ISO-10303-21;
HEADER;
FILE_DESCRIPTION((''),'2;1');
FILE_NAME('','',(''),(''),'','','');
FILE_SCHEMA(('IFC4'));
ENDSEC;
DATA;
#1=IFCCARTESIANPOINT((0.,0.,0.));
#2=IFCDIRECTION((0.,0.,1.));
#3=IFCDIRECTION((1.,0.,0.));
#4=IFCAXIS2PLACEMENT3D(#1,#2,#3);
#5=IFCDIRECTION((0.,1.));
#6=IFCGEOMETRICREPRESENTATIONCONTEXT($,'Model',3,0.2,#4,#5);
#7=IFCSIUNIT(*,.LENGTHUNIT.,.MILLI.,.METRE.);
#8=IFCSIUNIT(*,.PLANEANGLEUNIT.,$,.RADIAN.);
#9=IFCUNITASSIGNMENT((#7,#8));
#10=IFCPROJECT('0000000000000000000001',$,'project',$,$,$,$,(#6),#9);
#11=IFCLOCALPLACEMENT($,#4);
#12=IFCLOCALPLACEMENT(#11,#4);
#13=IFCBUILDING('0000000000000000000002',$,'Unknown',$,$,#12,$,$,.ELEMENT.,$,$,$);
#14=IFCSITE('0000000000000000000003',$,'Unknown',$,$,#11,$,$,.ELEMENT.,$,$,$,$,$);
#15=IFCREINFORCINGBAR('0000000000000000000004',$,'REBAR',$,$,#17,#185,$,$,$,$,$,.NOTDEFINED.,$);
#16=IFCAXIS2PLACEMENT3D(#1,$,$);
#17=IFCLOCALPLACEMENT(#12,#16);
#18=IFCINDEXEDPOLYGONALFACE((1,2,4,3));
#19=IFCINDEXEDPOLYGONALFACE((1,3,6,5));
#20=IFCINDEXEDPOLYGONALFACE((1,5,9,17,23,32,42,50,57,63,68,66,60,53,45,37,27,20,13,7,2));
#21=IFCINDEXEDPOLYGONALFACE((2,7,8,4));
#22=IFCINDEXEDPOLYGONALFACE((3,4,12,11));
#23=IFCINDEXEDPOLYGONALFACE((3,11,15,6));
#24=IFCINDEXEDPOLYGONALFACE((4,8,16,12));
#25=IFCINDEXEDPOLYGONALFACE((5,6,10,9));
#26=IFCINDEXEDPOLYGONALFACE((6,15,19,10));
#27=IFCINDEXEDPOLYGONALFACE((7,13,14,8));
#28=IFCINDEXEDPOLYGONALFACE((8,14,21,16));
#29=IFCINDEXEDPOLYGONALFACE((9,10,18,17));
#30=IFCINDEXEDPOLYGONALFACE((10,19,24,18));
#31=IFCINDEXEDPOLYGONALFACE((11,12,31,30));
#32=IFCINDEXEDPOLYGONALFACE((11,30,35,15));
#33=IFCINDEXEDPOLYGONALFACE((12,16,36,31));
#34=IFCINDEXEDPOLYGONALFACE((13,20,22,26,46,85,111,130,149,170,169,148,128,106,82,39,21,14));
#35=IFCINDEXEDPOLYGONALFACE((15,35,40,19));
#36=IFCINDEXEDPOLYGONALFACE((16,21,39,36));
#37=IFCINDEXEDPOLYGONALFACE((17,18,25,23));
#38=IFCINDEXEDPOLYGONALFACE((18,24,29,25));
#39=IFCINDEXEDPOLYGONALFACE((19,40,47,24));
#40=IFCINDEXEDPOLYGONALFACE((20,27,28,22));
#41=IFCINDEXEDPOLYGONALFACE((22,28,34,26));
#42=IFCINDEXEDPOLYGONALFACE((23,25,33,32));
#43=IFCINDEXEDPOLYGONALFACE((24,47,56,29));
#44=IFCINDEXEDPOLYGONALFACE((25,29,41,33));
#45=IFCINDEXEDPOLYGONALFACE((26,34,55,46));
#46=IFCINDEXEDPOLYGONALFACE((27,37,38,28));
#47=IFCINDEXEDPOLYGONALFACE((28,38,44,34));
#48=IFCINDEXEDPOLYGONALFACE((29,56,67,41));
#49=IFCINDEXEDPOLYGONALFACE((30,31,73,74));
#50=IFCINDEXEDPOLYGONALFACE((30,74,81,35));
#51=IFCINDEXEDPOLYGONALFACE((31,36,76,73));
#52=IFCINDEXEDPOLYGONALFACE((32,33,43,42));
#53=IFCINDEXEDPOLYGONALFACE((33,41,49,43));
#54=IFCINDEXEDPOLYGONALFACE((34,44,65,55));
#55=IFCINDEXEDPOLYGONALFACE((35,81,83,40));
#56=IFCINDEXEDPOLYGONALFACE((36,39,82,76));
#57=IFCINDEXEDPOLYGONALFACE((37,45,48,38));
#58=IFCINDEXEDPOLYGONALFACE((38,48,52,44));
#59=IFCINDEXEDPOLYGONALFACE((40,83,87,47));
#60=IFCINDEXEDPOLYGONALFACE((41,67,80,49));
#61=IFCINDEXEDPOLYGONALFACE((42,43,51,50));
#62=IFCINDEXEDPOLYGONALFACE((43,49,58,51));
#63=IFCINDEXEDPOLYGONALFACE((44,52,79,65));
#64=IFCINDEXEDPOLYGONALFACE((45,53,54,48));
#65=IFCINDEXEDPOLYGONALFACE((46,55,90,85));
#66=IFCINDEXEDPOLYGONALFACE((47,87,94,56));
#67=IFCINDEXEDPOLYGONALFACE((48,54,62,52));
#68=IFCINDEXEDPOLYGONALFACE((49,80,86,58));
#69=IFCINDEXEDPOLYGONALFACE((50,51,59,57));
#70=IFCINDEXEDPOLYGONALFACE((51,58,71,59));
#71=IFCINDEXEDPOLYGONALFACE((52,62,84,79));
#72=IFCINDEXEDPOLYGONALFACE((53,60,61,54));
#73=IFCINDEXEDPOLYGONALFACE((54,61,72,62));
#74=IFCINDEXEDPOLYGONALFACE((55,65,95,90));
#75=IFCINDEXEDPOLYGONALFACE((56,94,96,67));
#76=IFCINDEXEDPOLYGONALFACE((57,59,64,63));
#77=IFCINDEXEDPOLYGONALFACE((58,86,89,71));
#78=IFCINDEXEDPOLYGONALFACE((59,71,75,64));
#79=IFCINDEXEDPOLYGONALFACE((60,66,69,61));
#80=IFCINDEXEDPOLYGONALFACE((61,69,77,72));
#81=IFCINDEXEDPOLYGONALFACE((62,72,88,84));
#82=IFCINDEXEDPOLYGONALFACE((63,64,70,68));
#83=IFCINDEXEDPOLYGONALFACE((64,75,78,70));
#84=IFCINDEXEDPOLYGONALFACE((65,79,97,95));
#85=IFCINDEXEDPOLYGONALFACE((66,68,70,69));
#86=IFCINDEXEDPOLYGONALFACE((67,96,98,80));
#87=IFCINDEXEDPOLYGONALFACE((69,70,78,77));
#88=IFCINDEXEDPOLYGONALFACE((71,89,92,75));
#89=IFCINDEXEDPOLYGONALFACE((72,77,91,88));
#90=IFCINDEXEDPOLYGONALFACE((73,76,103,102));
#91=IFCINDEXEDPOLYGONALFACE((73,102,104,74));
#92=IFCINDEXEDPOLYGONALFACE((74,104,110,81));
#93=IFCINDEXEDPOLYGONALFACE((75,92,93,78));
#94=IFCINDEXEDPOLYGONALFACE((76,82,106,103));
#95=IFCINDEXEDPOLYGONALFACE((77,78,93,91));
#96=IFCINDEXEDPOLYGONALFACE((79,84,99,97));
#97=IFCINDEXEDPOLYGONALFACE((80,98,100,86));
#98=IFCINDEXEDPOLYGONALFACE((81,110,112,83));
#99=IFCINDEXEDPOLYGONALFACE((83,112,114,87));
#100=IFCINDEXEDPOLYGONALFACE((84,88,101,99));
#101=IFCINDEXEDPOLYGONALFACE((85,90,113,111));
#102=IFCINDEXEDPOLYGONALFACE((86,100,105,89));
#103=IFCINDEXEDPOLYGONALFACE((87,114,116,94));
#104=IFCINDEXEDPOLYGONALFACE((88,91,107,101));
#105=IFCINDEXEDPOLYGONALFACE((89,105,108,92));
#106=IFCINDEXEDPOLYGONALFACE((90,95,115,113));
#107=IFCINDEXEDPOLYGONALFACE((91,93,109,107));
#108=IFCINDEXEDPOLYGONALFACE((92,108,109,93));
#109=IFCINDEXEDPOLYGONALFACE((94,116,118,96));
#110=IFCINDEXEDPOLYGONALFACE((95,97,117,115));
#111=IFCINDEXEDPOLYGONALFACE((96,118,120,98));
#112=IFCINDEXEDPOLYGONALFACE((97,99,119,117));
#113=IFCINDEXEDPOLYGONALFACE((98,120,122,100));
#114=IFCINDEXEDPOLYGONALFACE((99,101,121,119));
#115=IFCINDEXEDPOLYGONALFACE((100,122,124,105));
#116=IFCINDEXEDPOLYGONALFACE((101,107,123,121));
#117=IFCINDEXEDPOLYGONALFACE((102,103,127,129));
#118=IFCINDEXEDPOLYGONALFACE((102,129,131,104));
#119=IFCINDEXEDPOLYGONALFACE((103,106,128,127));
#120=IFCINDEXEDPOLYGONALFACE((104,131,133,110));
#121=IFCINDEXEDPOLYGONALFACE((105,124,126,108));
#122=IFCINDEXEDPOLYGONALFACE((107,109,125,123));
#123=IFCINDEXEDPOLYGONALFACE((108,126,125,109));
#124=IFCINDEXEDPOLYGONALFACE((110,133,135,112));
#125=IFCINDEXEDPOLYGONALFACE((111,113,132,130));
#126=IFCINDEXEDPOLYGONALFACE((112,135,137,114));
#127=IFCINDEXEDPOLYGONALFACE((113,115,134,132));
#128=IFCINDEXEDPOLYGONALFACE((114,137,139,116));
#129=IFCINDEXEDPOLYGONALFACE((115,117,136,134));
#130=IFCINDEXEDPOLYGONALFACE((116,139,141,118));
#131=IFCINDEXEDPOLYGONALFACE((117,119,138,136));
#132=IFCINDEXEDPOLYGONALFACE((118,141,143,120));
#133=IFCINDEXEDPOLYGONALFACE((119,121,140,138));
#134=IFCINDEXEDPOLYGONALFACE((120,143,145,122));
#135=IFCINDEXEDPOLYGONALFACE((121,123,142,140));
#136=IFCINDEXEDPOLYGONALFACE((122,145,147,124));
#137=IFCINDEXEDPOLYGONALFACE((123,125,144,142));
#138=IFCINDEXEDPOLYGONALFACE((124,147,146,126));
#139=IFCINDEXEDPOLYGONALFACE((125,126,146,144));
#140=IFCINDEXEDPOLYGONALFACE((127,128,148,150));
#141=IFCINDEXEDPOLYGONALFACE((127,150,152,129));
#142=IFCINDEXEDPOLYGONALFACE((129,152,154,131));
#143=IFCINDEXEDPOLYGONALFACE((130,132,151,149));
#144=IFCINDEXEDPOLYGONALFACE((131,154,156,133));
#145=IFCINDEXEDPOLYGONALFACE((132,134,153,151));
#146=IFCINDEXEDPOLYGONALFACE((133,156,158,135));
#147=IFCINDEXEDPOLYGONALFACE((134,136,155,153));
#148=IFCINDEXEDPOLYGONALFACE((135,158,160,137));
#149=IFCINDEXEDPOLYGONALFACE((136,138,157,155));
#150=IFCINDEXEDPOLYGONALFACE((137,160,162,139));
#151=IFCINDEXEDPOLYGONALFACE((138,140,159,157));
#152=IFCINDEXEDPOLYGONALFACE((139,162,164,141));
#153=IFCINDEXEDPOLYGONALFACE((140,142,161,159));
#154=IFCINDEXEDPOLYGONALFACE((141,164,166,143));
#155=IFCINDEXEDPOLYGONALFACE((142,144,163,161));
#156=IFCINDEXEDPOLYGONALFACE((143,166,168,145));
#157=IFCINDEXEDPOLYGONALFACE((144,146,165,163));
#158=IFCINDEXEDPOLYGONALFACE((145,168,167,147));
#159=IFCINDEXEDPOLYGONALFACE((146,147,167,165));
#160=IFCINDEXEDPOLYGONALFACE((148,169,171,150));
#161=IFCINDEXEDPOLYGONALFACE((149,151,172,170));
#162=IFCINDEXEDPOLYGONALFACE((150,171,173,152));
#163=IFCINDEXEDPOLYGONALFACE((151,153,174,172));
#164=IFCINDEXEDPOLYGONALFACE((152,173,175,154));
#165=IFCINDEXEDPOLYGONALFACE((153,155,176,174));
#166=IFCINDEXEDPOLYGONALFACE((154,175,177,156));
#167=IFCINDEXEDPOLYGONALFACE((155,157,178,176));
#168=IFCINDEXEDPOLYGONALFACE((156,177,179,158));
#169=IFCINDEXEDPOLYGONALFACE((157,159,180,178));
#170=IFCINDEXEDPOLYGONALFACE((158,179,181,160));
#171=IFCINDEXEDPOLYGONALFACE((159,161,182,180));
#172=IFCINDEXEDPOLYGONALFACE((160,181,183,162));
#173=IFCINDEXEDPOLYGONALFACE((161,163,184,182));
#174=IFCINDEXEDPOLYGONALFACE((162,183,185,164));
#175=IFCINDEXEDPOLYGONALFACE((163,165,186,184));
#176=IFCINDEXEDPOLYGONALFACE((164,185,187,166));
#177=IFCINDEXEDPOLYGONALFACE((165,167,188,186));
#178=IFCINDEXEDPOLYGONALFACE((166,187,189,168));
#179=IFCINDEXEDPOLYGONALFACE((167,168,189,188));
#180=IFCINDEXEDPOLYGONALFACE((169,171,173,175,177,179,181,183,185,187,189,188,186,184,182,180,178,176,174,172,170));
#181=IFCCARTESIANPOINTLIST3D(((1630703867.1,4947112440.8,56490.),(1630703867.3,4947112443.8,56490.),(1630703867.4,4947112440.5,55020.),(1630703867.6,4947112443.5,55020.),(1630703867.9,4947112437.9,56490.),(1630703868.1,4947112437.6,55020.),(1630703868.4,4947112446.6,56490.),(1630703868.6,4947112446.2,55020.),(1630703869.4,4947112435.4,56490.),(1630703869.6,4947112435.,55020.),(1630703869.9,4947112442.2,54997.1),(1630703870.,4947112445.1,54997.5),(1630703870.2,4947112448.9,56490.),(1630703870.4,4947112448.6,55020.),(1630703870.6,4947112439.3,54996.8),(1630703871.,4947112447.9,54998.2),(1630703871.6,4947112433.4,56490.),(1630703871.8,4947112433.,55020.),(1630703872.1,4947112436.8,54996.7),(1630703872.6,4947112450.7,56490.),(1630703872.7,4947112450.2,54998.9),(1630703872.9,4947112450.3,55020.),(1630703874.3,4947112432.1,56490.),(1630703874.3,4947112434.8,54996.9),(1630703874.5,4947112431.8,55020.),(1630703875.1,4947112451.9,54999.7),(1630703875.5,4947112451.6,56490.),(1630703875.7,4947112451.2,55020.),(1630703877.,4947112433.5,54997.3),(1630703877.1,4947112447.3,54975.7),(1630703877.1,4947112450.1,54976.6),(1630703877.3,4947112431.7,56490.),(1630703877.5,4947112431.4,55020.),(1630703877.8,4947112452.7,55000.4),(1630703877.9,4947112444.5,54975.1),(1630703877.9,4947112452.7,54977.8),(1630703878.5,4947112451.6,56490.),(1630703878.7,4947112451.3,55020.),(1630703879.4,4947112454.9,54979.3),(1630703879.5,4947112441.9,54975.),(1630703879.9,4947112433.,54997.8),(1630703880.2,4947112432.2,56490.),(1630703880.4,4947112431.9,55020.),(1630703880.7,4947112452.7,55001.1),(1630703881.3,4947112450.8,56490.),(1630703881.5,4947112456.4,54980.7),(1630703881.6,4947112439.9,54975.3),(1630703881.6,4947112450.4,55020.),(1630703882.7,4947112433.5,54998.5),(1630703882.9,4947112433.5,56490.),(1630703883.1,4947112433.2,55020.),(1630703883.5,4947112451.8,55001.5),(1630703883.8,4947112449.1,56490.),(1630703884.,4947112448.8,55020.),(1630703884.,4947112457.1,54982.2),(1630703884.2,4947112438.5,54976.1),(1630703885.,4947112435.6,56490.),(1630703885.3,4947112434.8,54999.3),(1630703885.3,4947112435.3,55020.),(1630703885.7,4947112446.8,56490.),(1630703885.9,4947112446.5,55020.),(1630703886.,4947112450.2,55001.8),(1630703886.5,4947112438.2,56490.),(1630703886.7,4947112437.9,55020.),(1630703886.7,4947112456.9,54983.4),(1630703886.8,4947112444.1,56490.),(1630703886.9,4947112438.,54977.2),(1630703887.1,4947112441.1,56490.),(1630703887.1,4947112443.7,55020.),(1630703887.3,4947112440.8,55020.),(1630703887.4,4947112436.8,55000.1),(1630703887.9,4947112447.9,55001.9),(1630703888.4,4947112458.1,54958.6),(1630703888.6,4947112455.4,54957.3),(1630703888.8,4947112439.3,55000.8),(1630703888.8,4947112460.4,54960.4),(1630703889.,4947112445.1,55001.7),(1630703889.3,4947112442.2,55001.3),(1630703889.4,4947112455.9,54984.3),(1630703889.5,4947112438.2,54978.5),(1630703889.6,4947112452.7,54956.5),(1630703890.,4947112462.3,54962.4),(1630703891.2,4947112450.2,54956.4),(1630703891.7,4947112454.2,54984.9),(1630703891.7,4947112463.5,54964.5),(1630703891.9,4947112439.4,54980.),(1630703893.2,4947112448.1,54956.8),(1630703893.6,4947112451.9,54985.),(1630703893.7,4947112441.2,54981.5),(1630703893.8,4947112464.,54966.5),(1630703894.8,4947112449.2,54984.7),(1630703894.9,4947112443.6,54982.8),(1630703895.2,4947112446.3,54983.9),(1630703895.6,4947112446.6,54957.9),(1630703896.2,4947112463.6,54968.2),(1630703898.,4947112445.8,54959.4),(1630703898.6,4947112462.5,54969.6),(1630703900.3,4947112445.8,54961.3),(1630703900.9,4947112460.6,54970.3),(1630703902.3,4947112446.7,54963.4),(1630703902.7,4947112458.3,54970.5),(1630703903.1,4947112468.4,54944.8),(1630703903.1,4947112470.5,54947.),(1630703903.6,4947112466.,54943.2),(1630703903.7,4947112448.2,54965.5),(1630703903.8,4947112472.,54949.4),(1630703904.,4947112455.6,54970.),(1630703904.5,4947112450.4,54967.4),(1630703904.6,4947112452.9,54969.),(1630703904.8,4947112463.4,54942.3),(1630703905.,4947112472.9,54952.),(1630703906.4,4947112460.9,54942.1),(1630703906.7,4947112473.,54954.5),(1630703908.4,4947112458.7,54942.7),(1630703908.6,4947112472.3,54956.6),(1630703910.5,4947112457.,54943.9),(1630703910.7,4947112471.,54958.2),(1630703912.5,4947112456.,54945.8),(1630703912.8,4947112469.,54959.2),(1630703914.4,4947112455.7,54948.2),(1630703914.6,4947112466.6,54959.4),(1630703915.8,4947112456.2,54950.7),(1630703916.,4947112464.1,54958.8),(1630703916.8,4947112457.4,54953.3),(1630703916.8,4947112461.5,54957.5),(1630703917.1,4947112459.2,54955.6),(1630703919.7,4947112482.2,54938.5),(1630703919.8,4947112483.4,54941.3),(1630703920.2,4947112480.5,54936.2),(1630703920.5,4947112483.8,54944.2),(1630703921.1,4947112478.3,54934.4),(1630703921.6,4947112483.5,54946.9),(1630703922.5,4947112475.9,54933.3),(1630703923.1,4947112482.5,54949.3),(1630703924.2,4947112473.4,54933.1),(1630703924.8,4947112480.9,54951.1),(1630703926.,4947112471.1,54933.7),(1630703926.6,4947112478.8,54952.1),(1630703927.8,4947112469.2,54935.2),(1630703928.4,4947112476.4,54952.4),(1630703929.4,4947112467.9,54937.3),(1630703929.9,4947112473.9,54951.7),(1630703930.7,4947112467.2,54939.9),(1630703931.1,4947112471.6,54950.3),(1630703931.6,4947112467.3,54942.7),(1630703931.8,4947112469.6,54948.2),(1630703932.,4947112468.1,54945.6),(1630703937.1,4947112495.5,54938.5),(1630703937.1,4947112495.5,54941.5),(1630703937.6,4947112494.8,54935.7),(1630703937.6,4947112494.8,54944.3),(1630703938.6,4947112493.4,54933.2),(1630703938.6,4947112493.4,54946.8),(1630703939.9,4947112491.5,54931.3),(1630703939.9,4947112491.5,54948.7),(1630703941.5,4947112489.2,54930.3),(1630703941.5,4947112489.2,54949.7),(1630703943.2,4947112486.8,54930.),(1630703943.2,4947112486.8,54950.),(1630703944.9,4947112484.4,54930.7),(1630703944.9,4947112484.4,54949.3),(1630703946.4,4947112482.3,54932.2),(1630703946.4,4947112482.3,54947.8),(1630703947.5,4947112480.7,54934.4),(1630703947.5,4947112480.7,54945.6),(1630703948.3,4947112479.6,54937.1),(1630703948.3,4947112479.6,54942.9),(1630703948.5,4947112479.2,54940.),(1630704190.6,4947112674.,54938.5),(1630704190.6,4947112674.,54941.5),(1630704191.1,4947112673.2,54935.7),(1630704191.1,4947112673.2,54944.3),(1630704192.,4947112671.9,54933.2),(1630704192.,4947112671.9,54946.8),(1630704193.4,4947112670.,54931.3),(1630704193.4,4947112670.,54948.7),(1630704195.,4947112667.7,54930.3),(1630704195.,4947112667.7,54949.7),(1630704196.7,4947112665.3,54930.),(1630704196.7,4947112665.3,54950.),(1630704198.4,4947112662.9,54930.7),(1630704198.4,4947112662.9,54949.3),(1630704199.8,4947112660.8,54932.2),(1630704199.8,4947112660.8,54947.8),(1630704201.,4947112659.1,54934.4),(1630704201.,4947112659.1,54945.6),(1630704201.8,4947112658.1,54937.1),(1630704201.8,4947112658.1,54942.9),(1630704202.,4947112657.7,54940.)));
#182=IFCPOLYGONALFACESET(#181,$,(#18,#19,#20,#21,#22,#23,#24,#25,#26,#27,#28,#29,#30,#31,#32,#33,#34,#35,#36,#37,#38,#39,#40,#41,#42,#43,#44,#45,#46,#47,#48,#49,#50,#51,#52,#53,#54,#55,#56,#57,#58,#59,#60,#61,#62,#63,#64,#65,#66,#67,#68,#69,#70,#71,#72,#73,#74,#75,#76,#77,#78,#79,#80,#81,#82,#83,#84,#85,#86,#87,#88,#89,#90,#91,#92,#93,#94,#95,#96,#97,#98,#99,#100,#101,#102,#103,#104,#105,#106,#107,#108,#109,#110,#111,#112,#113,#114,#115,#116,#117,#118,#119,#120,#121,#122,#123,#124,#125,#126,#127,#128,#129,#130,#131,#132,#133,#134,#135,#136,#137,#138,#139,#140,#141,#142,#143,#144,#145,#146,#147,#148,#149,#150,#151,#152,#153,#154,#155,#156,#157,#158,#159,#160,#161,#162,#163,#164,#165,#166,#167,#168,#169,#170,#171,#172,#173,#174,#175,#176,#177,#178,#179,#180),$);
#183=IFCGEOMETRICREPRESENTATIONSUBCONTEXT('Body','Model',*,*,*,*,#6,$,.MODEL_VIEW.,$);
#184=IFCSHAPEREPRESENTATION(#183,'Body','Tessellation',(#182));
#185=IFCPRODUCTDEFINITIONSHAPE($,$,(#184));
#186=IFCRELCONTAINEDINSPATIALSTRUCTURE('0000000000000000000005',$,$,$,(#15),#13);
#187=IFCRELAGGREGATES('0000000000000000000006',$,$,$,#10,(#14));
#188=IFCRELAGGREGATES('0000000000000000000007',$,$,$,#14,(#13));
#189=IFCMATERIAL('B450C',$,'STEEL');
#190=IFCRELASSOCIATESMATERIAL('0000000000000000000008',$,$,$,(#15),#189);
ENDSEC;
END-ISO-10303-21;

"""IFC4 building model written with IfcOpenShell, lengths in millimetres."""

from ifc_helpers import new_model, entity, si_unit, direction, frame, origin_with_axes, place, context, subcontext, project, spatial, material, element, save


model = new_model("IFC4")

# Units and contexts
model_context = context("Model", 3, precision=0.2, world=origin_with_axes(), true_north=direction((0.0, 1.0)))
body_context = subcontext(model_context, "Body", "Model", "MODEL_VIEW")
ifc_project = project(units=[si_unit("LENGTHUNIT", "METRE", prefix="MILLI"), si_unit("PLANEANGLEUNIT", "RADIAN")], contexts=[model_context])

# Site, building
site_placement = place(None, origin_with_axes())
site = spatial("IfcSite", under=ifc_project, at=site_placement, Name="Unknown", CompositionType="ELEMENT")
building_placement = place(site_placement, origin_with_axes())
building = spatial("IfcBuilding", under=site, at=building_placement, Name="Unknown", CompositionType="ELEMENT")

# Reinforcing bar
ifc_material = material(Name="B450C", Category="STEEL")
reinforcing_bar_1_placement = place(building_placement, frame((1630703807.7, 4947112453.4, 54890.0), z_axis=(0.575962, -0.817477, 0.0), x_axis=(0.0, 0.0, 1.0)))
element("IfcReinforcingBar", 1, at=reinforcing_bar_1_placement, inside=building, material=ifc_material, Name="REBAR", PredefinedType="NOTDEFINED", context=body_context, shape_type="AdvancedSweptSolid", body=[
    entity("IfcSweptDiskSolid", entity("IfcIndexedPolyCurve", entity("IfcCartesianPointList3D", [[50.0, -440.0, 50.1], [50.0, -130.0, 50.0], [73.4, -73.4, 50.0], [130.0, -50.0, 50.0], [1600.0, -50.0, 49.6]]), [entity("IfcLineIndex", [1, 2]), entity("IfcArcIndex", [2, 3, 4]), entity("IfcLineIndex", [4, 5])]), 10.0),
])

save(model, "model.ifc")
